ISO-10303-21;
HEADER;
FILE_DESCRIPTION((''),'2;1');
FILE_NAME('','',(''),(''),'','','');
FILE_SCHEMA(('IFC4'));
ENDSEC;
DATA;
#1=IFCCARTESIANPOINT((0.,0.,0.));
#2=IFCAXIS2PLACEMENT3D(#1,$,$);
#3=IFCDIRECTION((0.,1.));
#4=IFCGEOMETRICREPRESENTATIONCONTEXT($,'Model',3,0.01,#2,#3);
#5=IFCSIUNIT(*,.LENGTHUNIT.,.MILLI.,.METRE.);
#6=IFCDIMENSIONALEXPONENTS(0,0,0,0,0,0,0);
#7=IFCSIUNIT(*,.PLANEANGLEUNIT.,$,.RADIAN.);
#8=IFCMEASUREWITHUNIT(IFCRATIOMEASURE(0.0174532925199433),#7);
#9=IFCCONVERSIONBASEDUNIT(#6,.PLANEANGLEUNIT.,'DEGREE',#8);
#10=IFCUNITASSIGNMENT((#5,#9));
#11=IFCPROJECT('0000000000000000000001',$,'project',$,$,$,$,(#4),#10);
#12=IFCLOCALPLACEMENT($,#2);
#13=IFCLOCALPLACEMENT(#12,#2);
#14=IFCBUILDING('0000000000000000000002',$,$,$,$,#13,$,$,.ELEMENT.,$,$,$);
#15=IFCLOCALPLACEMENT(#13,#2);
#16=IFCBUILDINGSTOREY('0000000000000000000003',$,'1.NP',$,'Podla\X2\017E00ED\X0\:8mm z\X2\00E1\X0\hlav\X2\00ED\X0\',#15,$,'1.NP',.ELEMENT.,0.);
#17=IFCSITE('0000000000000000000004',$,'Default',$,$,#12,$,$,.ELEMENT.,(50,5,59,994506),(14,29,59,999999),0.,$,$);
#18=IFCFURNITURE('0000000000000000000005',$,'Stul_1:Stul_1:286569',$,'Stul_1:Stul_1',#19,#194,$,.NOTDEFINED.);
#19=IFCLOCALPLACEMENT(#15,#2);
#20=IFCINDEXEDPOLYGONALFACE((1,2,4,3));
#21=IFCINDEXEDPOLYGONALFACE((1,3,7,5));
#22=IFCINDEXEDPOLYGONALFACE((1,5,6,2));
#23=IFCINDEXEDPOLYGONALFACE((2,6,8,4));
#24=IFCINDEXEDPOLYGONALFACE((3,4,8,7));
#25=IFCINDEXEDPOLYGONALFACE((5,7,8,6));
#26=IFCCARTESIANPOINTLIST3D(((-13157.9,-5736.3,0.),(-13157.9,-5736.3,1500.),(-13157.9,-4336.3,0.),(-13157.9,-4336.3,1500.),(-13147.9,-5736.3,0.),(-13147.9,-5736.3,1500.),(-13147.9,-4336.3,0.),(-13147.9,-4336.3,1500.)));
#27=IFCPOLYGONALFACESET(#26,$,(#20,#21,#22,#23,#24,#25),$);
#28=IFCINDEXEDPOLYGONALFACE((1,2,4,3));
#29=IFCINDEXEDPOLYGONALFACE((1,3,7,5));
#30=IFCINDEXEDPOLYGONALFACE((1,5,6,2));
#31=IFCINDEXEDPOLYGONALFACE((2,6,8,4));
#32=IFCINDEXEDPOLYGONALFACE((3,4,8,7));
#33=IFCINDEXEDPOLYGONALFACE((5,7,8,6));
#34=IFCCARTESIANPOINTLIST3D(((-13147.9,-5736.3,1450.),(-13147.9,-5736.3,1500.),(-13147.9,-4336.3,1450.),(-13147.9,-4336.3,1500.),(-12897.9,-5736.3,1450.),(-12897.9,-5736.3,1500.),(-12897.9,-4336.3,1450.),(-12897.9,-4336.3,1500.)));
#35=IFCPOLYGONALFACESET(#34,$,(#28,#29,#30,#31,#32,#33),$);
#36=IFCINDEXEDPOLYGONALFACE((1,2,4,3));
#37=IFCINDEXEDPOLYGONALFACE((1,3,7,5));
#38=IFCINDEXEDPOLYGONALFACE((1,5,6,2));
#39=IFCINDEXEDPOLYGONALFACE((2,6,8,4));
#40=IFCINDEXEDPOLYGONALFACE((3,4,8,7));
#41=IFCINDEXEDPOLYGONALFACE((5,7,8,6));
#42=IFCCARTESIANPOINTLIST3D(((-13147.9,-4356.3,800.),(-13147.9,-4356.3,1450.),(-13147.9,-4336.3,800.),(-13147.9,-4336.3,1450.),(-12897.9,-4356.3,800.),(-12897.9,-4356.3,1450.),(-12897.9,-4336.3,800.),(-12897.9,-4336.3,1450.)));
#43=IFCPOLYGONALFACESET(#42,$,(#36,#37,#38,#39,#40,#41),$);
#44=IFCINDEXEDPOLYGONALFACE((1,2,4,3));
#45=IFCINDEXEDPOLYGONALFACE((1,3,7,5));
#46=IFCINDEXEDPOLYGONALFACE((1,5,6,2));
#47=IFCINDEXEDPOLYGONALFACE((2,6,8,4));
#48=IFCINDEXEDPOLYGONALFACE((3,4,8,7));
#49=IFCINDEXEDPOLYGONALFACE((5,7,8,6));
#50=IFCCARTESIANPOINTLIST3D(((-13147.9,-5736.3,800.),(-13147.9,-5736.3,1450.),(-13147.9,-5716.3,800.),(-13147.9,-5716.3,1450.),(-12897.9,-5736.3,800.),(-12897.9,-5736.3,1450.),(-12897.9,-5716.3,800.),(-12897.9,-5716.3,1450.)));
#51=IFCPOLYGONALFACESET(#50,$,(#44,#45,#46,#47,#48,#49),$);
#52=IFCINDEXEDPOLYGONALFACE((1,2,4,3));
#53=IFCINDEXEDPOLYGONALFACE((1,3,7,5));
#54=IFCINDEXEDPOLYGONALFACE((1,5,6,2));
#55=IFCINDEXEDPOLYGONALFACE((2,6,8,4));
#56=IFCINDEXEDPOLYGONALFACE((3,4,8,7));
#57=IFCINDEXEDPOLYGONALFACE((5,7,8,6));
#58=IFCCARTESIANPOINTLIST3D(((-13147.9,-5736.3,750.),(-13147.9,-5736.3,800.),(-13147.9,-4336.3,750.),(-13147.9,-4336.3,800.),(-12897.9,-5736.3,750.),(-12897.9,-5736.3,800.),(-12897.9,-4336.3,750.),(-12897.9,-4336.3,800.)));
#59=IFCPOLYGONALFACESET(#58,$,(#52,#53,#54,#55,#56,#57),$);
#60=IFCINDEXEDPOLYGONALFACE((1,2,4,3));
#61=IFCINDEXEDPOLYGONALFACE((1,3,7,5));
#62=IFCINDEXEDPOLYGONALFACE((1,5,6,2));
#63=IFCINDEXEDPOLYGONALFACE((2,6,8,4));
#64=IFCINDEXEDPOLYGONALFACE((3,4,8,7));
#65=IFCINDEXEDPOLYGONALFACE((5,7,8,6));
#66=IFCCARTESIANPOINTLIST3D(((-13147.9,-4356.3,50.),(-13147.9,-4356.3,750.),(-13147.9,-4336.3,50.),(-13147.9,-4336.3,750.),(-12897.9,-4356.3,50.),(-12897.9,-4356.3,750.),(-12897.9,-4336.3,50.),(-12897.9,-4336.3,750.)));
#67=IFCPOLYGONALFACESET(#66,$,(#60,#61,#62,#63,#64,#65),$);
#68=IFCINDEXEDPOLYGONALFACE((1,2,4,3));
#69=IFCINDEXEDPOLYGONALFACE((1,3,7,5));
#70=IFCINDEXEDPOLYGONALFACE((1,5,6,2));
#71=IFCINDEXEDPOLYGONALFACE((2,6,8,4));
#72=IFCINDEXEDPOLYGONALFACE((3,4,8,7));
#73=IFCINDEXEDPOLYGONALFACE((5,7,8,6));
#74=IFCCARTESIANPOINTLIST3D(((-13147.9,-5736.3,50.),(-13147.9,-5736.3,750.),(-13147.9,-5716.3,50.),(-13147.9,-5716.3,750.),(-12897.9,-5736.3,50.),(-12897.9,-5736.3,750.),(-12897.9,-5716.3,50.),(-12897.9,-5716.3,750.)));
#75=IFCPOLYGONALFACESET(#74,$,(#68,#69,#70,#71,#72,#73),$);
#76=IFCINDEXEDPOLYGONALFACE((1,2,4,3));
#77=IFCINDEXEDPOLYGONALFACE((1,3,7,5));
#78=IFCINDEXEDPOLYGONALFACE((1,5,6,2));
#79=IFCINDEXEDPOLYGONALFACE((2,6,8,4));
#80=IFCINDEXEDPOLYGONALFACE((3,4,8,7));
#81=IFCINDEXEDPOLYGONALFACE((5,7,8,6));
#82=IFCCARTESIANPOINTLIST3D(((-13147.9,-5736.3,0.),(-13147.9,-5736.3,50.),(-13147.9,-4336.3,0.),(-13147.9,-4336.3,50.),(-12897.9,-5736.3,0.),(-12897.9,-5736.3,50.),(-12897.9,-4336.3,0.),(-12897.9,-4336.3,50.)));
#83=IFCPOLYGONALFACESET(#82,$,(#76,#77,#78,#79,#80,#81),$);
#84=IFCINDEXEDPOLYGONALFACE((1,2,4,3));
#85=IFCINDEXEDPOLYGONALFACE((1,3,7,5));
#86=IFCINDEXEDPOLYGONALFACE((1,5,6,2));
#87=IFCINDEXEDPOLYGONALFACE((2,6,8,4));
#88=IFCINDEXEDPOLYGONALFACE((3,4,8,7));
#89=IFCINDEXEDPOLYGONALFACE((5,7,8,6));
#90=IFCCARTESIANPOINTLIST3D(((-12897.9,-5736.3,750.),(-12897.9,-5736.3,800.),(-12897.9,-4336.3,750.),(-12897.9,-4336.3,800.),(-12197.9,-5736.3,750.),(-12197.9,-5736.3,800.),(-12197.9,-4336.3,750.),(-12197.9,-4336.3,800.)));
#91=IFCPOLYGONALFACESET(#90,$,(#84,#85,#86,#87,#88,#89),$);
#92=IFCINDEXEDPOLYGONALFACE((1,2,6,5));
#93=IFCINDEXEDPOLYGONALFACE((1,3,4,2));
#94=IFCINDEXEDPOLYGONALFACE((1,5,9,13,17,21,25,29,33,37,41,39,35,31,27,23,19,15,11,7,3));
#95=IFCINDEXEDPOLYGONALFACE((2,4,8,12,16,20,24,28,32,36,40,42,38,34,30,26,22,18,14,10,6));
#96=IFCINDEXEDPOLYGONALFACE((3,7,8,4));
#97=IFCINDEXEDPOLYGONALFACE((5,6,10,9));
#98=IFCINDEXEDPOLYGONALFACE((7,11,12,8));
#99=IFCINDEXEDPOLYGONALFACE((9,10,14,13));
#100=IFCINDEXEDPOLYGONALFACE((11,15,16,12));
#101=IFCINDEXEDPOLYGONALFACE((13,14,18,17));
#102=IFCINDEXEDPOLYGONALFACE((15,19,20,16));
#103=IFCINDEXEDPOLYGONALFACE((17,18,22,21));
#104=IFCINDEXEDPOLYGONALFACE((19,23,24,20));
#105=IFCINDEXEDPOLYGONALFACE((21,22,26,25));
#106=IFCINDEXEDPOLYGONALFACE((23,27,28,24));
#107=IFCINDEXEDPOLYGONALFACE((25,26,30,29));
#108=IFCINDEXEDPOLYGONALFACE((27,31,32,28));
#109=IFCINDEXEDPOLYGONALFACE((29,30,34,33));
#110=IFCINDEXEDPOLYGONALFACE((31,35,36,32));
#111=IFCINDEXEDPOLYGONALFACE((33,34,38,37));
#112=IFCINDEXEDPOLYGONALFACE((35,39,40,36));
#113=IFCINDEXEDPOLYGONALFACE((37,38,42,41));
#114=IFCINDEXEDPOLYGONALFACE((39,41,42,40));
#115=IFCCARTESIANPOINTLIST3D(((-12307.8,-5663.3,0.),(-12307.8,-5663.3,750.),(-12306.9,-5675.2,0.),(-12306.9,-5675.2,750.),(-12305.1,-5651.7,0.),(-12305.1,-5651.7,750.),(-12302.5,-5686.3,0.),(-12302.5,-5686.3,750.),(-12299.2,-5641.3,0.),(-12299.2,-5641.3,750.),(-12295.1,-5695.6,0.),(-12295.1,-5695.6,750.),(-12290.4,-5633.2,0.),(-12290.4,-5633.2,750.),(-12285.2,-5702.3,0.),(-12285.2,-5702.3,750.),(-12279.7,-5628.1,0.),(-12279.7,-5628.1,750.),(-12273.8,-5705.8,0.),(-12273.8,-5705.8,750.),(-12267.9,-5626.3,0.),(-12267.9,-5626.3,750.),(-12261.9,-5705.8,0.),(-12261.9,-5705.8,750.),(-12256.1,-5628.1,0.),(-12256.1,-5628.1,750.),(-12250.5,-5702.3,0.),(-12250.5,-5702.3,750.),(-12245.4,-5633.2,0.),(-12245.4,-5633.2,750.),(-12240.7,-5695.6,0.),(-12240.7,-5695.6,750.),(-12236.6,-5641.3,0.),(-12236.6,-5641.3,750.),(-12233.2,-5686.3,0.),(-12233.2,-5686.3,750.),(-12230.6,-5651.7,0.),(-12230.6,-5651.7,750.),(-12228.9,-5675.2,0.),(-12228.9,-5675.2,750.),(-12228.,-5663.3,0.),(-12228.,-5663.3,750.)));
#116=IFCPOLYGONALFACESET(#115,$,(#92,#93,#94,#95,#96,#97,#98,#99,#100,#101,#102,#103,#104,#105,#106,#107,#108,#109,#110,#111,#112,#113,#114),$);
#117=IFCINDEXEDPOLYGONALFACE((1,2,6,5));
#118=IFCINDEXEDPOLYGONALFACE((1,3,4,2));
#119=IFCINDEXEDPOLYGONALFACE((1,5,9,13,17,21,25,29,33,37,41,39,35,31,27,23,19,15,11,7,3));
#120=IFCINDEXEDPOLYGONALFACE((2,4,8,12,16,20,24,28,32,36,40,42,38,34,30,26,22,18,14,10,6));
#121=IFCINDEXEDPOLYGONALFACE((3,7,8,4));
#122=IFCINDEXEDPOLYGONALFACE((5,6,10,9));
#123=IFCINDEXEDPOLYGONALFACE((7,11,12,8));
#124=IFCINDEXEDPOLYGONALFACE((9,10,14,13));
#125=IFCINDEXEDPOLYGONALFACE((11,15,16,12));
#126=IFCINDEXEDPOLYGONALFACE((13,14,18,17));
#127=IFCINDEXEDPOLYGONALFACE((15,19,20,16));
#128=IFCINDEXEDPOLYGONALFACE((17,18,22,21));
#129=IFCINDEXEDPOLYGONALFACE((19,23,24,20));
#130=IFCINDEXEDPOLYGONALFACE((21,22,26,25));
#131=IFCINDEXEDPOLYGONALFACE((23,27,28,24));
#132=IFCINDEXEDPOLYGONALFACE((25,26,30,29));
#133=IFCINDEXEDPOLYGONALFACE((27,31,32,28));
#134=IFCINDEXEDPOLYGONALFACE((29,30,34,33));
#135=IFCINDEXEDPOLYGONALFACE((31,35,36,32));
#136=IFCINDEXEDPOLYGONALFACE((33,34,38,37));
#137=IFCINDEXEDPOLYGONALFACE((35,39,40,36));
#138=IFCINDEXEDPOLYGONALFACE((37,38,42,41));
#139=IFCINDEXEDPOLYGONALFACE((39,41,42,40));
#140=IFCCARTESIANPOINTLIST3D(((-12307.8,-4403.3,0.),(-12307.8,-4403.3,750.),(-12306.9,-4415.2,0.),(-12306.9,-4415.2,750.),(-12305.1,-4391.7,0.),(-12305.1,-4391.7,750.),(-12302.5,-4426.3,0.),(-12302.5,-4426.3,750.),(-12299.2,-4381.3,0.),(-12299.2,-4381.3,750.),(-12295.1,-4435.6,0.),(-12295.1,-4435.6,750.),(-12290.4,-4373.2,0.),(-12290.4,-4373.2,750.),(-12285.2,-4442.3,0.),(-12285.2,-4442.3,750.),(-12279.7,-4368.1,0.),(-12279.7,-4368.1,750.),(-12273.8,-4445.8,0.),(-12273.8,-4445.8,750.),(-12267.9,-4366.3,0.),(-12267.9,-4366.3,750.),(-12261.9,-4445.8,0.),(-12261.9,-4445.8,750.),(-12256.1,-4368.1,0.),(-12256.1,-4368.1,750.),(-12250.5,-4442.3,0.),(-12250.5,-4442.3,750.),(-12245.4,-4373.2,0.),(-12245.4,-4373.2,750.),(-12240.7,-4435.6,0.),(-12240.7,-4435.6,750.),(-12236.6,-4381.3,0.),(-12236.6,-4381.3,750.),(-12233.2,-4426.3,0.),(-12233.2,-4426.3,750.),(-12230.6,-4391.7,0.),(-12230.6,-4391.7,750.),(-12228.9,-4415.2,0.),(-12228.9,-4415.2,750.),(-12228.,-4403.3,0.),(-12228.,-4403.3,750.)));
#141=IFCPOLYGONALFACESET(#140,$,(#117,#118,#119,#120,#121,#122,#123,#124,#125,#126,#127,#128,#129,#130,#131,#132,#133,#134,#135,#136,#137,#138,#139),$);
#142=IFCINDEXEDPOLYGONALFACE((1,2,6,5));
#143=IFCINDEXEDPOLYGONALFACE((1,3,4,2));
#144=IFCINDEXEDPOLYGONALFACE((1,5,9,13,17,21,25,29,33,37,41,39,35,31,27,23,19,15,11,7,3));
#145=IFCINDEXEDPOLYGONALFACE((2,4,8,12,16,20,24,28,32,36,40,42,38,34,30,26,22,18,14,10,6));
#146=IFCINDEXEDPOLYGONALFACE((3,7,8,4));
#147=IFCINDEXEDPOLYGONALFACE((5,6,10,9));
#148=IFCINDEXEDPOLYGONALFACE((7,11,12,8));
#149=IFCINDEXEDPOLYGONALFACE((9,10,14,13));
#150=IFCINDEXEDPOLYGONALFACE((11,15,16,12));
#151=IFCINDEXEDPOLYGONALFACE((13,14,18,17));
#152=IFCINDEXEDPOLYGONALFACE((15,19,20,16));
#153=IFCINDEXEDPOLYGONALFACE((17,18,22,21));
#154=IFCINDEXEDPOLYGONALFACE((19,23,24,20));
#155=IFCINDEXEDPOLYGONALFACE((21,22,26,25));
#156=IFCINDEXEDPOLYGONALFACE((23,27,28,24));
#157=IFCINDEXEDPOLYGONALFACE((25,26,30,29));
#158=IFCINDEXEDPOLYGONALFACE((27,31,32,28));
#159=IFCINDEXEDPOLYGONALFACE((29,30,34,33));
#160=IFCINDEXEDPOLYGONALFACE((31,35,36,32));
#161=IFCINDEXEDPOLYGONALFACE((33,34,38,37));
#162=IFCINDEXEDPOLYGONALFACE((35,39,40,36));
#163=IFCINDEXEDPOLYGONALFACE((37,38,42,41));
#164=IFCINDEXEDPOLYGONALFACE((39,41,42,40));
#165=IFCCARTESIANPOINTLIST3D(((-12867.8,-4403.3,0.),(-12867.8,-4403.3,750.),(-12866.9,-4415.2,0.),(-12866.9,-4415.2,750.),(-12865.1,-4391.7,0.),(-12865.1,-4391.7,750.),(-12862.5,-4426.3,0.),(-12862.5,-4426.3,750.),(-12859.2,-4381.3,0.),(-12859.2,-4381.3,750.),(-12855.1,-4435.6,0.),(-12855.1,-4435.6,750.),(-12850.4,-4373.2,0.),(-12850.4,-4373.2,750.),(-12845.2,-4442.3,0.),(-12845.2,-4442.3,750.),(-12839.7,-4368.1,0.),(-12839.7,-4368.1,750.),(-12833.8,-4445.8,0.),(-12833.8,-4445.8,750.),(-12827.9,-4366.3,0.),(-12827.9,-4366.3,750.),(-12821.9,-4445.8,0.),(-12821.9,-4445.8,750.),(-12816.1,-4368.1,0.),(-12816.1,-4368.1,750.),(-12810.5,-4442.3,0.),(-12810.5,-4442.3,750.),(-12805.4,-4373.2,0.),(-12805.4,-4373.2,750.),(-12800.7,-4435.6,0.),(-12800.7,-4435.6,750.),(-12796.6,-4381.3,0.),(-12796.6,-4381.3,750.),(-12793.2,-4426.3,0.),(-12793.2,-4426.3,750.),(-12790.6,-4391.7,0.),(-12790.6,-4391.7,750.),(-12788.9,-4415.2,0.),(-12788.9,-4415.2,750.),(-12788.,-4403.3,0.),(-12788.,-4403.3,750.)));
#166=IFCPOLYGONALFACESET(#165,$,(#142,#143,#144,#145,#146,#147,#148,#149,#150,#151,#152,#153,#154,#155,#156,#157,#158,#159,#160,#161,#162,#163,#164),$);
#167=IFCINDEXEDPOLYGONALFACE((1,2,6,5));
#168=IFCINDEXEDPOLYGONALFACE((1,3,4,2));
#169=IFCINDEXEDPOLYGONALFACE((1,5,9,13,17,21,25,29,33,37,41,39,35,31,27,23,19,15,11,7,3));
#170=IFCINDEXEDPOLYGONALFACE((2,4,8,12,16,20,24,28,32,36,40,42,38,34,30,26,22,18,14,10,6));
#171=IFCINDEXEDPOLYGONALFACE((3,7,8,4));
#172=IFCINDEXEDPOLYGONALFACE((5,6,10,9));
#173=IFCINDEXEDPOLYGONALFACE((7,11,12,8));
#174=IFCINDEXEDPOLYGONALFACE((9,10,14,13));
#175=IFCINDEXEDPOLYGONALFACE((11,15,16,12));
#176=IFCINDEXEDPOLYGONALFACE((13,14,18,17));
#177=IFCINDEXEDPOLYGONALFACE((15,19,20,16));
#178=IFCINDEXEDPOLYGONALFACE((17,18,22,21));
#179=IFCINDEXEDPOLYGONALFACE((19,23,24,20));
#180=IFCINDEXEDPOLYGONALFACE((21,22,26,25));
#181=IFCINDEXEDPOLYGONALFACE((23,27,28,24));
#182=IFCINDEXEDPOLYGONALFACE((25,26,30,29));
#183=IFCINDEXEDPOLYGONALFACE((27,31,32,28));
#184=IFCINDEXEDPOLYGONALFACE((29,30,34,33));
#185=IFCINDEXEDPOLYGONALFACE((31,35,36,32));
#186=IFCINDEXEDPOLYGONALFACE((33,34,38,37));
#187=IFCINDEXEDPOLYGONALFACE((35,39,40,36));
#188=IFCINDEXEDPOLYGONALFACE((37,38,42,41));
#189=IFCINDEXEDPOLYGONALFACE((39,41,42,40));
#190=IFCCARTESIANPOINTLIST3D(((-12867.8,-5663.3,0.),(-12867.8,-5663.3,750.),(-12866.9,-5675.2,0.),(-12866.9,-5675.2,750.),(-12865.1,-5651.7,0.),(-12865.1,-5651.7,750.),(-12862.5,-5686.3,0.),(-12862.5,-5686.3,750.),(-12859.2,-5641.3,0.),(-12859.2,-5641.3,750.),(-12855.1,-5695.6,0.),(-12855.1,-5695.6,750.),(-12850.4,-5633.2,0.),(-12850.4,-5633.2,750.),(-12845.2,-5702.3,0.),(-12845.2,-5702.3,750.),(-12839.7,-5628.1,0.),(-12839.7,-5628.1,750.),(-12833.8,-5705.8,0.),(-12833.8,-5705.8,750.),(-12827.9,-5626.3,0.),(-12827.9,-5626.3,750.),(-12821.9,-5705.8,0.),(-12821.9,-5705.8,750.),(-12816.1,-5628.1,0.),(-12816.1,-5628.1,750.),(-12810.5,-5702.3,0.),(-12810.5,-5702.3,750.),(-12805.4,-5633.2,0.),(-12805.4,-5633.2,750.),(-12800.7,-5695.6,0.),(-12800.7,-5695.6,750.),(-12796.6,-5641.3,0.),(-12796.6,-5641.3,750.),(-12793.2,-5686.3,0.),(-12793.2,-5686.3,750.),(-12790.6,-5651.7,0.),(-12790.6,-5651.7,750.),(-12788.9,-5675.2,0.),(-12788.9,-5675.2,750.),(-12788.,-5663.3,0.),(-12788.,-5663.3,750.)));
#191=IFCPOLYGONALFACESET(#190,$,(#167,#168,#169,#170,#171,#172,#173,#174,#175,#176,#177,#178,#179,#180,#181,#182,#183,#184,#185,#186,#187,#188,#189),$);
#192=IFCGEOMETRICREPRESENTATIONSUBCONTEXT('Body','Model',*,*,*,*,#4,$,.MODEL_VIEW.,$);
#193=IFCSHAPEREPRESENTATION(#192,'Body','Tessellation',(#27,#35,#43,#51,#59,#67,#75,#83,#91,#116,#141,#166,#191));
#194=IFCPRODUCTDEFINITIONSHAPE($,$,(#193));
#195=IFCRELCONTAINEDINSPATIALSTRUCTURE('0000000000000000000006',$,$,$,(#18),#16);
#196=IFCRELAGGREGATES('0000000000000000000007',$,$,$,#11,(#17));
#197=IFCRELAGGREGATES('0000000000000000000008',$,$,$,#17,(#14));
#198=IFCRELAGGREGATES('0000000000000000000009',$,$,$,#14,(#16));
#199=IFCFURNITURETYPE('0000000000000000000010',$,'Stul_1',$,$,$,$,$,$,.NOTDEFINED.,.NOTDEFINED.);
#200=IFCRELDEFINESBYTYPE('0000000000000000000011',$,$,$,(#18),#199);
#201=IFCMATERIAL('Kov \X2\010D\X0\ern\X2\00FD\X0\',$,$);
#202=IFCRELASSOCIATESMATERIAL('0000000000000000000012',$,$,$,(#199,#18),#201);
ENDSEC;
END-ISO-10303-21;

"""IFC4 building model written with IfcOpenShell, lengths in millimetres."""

from ifc_helpers import new_model, entity, si_unit, converted_unit, direction, frame, frame_2d, origin, origin_2d_with_axis, place, context, subcontext, project, spatial, rectangle, circle, extrude, source, transform, mapped, material, type_object, type_shapes, element, save


model = new_model("IFC4")

# Units and contexts
model_context = context("Model", 3, precision=0.01, world=origin(), true_north=direction((0.0, 1.0)))
body_context = subcontext(model_context, "Body", "Model", "MODEL_VIEW")
ifc_project = project(units=[si_unit("LENGTHUNIT", "METRE", prefix="MILLI"), converted_unit("PLANEANGLEUNIT", "DEGREE", entity("IfcRatioMeasure", 0.0174532925199433), si_unit("PLANEANGLEUNIT", "RADIAN"), dimensions=[0, 0, 0, 0, 0, 0, 0])], contexts=[model_context])

# Site, building, storey
site_placement = place(None, origin())
site = spatial("IfcSite", under=ifc_project, at=site_placement, Name="Default", CompositionType="ELEMENT", RefLatitude=(50, 5, 59, 994506), RefLongitude=(14, 29, 59, 999999), RefElevation=0.0)
building_placement = place(site_placement, origin())
building = spatial("IfcBuilding", under=site, at=building_placement, CompositionType="ELEMENT")
storey_placement = place(building_placement, origin())
storey = spatial("IfcBuildingStorey", under=building, at=storey_placement, Name="1.NP", ObjectType="Podlaží:8mm záhlaví", LongName="1.NP", CompositionType="ELEMENT", Elevation=0.0)

# Furniture
ifc_material_1 = material(Name="Kov černý")
furniture_type = type_object("IfcFurnitureType", Name="Stul_1", AssemblyPlace="NOTDEFINED", PredefinedType="NOTDEFINED", material=ifc_material_1)
shared_shape_1 = source(origin(), body_context, "Body", "SweptSolid", [
    extrude(rectangle(XDim=1400.0, YDim=10.0, at=origin_2d_with_axis()), frame((0.0, 605.0, 0.0), z_axis=(0.0, 0.0, 1.0), x_axis=(-1.0, 0.0, 0.0)), (0.0, 0.0, 1.0), 1500.0),
    extrude(rectangle(XDim=1400.0, YDim=250.0, at=frame_2d((0.0, 0.0), x_axis=(1.0, 0.0))), frame((0.0, 475.0, 1450.0), z_axis=(0.0, 0.0, 1.0), x_axis=(-1.0, 0.0, 0.0)), (0.0, 0.0, 1.0), 50.0),
    extrude(rectangle(XDim=20.0, YDim=250.0, at=origin_2d_with_axis()), frame((690.0, 475.0, 800.0), z_axis=(0.0, 0.0, 1.0), x_axis=(-1.0, 0.0, 0.0)), (0.0, 0.0, 1.0), 650.0),
    extrude(rectangle(XDim=20.0, YDim=250.0, at=frame_2d((0.0, 0.0), x_axis=(1.0, 0.0))), frame((-690.0, 475.0, 800.0), z_axis=(0.0, 0.0, 1.0), x_axis=(-1.0, 0.0, 0.0)), (0.0, 0.0, 1.0), 650.0),
    extrude(rectangle(XDim=1400.0, YDim=250.0, at=origin_2d_with_axis()), frame((0.0, 475.0, 750.0), z_axis=(0.0, 0.0, 1.0), x_axis=(-1.0, 0.0, 0.0)), (0.0, 0.0, 1.0), 50.0),
    extrude(rectangle(XDim=20.0, YDim=250.0, at=origin_2d_with_axis()), frame((690.0, 475.0, 50.0), z_axis=(0.0, 0.0, 1.0), x_axis=(-1.0, 0.0, 0.0)), (0.0, 0.0, 1.0), 700.0),
    extrude(rectangle(XDim=20.0, YDim=250.0, at=frame_2d((0.0, 0.0), x_axis=(1.0, 0.0))), frame((-690.0, 475.0, 50.0), z_axis=(0.0, 0.0, 1.0), x_axis=(-1.0, 0.0, 0.0)), (0.0, 0.0, 1.0), 700.0),
    extrude(rectangle(XDim=1400.0, YDim=250.0, at=origin_2d_with_axis()), frame((0.0, 475.0, 0.0), z_axis=(0.0, 0.0, 1.0), x_axis=(-1.0, 0.0, 0.0)), (0.0, 0.0, 1.0), 50.0),
    extrude(rectangle(XDim=1400.0, YDim=700.0, at=origin_2d_with_axis()), frame((0.0, 0.0, 750.0), z_axis=(0.0, 0.0, 1.0), x_axis=(-1.0, 0.0, 0.0)), (0.0, 0.0, 1.0), 50.0),
    extrude(circle(Radius=40.0, at=frame_2d((0.0, 0.0), x_axis=(1.0, 0.0))), frame((-630.0, -280.0, 0.0)), (0.0, 0.0, 1.0), 750.0),
    extrude(circle(Radius=40.0, at=frame_2d((0.0, 0.0), x_axis=(1.0, 0.0))), frame((630.0, -280.0, 0.0)), (0.0, 0.0, 1.0), 750.0),
    extrude(circle(Radius=40.0, at=frame_2d((0.0, 0.0), x_axis=(1.0, 0.0))), frame((630.0, 280.0, 0.0)), (0.0, 0.0, 1.0), 750.0),
    extrude(circle(Radius=40.0, at=frame_2d((0.0, 0.0), x_axis=(1.0, 0.0))), frame((-630.0, 280.0, 0.0)), (0.0, 0.0, 1.0), 750.0),
])
type_shapes(furniture_type, [shared_shape_1])
for number, where, z_axis, x_axis, name in (
    (1, (-12547.9, -5036.3, 0.0), (0.0, 0.0, 1.0), (0.0, 1.0, 0.0), "Stul_1:Stul_1:286569"),
):
    element("IfcFurniture", number, at=place(storey_placement, frame(where, z_axis=z_axis, x_axis=x_axis)), inside=storey, type_object=furniture_type, material=ifc_material_1, Name=name, ObjectType="Stul_1:Stul_1", PredefinedType="NOTDEFINED", context=body_context, shape_type="MappedRepresentation", body=[
        mapped(shared_shape_1, transform((0.0, 0.0, 0.0), scale=1.0)),
    ])

save(model, "model.ifc")
